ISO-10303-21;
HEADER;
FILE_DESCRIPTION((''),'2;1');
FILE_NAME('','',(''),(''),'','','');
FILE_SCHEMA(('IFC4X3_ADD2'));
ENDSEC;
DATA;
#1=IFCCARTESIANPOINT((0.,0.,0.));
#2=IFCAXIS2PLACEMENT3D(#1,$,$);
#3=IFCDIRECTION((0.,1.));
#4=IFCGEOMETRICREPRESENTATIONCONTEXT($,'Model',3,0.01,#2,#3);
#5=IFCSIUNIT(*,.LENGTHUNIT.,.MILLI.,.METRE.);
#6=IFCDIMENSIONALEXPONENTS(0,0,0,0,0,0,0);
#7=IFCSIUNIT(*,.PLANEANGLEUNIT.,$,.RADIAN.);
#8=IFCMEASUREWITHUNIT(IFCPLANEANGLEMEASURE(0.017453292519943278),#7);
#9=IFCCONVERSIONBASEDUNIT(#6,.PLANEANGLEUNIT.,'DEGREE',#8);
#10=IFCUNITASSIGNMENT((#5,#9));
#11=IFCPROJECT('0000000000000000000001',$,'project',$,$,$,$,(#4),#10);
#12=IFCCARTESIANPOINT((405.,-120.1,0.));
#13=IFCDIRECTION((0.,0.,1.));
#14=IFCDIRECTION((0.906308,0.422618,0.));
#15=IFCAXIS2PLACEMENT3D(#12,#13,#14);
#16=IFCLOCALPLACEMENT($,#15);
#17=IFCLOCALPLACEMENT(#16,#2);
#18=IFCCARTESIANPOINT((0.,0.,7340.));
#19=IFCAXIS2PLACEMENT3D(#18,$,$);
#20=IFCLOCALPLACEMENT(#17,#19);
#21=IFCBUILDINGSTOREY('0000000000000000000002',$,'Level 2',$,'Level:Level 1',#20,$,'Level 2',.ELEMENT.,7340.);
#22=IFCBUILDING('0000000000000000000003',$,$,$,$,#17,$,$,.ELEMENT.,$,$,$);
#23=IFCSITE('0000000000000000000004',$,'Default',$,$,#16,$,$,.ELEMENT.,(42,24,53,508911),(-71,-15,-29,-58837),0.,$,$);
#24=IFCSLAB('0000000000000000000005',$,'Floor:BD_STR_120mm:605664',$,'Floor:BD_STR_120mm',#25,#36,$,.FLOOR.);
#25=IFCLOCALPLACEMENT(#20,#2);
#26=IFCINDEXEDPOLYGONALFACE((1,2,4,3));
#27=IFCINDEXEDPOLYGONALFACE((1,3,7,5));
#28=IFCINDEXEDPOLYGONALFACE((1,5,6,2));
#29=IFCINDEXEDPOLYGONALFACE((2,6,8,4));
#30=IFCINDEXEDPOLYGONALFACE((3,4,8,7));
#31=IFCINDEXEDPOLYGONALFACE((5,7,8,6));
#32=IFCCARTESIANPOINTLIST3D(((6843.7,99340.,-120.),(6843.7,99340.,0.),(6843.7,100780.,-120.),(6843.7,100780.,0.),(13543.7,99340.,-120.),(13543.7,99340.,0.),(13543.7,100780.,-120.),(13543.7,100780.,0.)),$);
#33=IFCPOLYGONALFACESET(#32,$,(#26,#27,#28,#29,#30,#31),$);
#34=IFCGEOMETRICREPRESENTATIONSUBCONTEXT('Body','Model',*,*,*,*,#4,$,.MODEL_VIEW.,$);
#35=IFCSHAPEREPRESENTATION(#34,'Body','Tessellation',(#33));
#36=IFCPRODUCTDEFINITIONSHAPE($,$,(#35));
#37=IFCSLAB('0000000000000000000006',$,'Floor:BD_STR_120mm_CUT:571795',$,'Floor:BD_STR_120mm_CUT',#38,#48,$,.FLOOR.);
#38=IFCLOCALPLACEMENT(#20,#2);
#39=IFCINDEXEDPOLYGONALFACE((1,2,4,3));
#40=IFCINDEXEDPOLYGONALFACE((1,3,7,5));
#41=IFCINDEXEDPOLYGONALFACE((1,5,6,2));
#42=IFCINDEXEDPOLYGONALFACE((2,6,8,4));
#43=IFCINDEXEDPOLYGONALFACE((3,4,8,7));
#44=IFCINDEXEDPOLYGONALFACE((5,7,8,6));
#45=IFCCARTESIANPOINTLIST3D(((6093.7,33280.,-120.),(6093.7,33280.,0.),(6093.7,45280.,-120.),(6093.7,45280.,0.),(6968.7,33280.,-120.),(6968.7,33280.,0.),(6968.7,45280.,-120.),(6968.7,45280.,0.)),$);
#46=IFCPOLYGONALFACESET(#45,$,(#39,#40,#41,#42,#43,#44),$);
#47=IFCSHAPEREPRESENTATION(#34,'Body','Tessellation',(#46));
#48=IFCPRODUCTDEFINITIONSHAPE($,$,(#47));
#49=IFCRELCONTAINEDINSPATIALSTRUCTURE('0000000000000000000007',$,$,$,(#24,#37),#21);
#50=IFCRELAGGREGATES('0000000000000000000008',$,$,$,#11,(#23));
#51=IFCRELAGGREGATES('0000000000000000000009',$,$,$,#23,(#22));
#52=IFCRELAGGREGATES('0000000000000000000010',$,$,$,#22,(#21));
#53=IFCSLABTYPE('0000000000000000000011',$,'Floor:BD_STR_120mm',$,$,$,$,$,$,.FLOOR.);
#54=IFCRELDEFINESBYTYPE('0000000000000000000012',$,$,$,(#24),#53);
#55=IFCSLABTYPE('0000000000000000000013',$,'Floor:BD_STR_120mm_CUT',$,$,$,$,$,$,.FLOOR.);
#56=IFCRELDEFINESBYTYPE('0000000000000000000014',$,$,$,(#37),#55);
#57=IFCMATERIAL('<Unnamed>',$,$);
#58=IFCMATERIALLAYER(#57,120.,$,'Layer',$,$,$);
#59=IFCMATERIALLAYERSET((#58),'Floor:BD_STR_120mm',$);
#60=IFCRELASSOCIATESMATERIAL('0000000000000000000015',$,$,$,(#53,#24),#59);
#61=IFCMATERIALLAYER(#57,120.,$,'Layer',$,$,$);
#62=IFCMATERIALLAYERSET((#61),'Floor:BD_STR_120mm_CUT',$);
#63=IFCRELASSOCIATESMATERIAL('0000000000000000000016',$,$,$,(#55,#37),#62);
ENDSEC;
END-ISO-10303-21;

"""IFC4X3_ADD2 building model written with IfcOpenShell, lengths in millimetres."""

from ifc_helpers import new_model, entity, si_unit, converted_unit, direction, frame, frame_2d, origin, place, context, subcontext, project, spatial, rectangle, extrude, material, layer, layer_set, layer_usage, type_object, element, save


model = new_model("IFC4X3_ADD2")

# Units and contexts
model_context = context("Model", 3, precision=0.01, world=origin(), true_north=direction((0.0, 1.0)))
body_context = subcontext(model_context, "Body", "Model", "MODEL_VIEW")
ifc_project = project(units=[si_unit("LENGTHUNIT", "METRE", prefix="MILLI"), converted_unit("PLANEANGLEUNIT", "DEGREE", entity("IfcPlaneAngleMeasure", 0.017453292519943278), si_unit("PLANEANGLEUNIT", "RADIAN"), dimensions=[0, 0, 0, 0, 0, 0, 0])], contexts=[model_context])

# Site, building, storey
site_placement = place(None, frame((405.0, -120.1, 0.0), z_axis=(0.0, 0.0, 1.0), x_axis=(0.906308, 0.422618, 0.0)))
site = spatial("IfcSite", under=ifc_project, at=site_placement, Name="Default", CompositionType="ELEMENT", RefLatitude=(42, 24, 53, 508911), RefLongitude=(-71, -15, -29, -58837), RefElevation=0.0)
building_placement = place(site_placement, origin())
building = spatial("IfcBuilding", under=site, at=building_placement, CompositionType="ELEMENT")
storey_placement = place(building_placement, frame((0.0, 0.0, 7340.0)))
storey = spatial("IfcBuildingStorey", under=building, at=storey_placement, Name="Level 2", ObjectType="Level:Level 1", LongName="Level 2", CompositionType="ELEMENT", Elevation=7340.0)

# Slabs
ifc_material_1 = material(Name="<Unnamed>")
ifc_layer_1 = layer(ifc_material_1, 120.0, Name="Layer")
ifc_layer_set_1 = layer_set([ifc_layer_1], Name="Floor:BD_STR_120mm")
slab_type_1 = type_object("IfcSlabType", Name="Floor:BD_STR_120mm", PredefinedType="FLOOR", material=ifc_layer_set_1)
ifc_layer_usage_1 = layer_usage(ifc_layer_set_1, "AXIS3", "POSITIVE", 0.0)
slab_1_placement = place(storey_placement, origin())
element("IfcSlab", 1, at=slab_1_placement, inside=storey, type_object=slab_type_1, material=ifc_layer_usage_1, Name="Floor:BD_STR_120mm:605664", ObjectType="Floor:BD_STR_120mm", PredefinedType="FLOOR", context=body_context, shape_type="SweptSolid", body=[
    extrude(rectangle(XDim=1440.0, YDim=6700.0, at=frame_2d((0.0, 0.0), x_axis=(1.0, 0.0))), frame((10193.7, 100060.0, 0.0), z_axis=(0.0, 0.0, -1.0), x_axis=(0.0, 1.0, 0.0)), (0.0, 0.0, 1.0), 120.0),
])
ifc_layer_2 = layer(ifc_material_1, 120.0, Name="Layer")
ifc_layer_set_2 = layer_set([ifc_layer_2], Name="Floor:BD_STR_120mm_CUT")
ifc_layer_usage_2 = layer_usage(ifc_layer_set_2, "AXIS3", "POSITIVE", 0.0)
slab_type_2 = type_object("IfcSlabType", Name="Floor:BD_STR_120mm_CUT", PredefinedType="FLOOR", material=ifc_layer_set_2)
slab_2_placement = place(storey_placement, origin())
element("IfcSlab", 2, at=slab_2_placement, inside=storey, type_object=slab_type_2, material=ifc_layer_usage_2, Name="Floor:BD_STR_120mm_CUT:571795", ObjectType="Floor:BD_STR_120mm_CUT", PredefinedType="FLOOR", context=body_context, shape_type="SweptSolid", body=[
    extrude(rectangle(XDim=12000.0, YDim=875.0, at=frame_2d((0.0, 0.0), x_axis=(1.0, 0.0))), frame((6531.2, 39280.0, 0.0), z_axis=(0.0, 0.0, -1.0), x_axis=(0.0, 1.0, 0.0)), (0.0, 0.0, 1.0), 120.0),
])

save(model, "model.ifc")
